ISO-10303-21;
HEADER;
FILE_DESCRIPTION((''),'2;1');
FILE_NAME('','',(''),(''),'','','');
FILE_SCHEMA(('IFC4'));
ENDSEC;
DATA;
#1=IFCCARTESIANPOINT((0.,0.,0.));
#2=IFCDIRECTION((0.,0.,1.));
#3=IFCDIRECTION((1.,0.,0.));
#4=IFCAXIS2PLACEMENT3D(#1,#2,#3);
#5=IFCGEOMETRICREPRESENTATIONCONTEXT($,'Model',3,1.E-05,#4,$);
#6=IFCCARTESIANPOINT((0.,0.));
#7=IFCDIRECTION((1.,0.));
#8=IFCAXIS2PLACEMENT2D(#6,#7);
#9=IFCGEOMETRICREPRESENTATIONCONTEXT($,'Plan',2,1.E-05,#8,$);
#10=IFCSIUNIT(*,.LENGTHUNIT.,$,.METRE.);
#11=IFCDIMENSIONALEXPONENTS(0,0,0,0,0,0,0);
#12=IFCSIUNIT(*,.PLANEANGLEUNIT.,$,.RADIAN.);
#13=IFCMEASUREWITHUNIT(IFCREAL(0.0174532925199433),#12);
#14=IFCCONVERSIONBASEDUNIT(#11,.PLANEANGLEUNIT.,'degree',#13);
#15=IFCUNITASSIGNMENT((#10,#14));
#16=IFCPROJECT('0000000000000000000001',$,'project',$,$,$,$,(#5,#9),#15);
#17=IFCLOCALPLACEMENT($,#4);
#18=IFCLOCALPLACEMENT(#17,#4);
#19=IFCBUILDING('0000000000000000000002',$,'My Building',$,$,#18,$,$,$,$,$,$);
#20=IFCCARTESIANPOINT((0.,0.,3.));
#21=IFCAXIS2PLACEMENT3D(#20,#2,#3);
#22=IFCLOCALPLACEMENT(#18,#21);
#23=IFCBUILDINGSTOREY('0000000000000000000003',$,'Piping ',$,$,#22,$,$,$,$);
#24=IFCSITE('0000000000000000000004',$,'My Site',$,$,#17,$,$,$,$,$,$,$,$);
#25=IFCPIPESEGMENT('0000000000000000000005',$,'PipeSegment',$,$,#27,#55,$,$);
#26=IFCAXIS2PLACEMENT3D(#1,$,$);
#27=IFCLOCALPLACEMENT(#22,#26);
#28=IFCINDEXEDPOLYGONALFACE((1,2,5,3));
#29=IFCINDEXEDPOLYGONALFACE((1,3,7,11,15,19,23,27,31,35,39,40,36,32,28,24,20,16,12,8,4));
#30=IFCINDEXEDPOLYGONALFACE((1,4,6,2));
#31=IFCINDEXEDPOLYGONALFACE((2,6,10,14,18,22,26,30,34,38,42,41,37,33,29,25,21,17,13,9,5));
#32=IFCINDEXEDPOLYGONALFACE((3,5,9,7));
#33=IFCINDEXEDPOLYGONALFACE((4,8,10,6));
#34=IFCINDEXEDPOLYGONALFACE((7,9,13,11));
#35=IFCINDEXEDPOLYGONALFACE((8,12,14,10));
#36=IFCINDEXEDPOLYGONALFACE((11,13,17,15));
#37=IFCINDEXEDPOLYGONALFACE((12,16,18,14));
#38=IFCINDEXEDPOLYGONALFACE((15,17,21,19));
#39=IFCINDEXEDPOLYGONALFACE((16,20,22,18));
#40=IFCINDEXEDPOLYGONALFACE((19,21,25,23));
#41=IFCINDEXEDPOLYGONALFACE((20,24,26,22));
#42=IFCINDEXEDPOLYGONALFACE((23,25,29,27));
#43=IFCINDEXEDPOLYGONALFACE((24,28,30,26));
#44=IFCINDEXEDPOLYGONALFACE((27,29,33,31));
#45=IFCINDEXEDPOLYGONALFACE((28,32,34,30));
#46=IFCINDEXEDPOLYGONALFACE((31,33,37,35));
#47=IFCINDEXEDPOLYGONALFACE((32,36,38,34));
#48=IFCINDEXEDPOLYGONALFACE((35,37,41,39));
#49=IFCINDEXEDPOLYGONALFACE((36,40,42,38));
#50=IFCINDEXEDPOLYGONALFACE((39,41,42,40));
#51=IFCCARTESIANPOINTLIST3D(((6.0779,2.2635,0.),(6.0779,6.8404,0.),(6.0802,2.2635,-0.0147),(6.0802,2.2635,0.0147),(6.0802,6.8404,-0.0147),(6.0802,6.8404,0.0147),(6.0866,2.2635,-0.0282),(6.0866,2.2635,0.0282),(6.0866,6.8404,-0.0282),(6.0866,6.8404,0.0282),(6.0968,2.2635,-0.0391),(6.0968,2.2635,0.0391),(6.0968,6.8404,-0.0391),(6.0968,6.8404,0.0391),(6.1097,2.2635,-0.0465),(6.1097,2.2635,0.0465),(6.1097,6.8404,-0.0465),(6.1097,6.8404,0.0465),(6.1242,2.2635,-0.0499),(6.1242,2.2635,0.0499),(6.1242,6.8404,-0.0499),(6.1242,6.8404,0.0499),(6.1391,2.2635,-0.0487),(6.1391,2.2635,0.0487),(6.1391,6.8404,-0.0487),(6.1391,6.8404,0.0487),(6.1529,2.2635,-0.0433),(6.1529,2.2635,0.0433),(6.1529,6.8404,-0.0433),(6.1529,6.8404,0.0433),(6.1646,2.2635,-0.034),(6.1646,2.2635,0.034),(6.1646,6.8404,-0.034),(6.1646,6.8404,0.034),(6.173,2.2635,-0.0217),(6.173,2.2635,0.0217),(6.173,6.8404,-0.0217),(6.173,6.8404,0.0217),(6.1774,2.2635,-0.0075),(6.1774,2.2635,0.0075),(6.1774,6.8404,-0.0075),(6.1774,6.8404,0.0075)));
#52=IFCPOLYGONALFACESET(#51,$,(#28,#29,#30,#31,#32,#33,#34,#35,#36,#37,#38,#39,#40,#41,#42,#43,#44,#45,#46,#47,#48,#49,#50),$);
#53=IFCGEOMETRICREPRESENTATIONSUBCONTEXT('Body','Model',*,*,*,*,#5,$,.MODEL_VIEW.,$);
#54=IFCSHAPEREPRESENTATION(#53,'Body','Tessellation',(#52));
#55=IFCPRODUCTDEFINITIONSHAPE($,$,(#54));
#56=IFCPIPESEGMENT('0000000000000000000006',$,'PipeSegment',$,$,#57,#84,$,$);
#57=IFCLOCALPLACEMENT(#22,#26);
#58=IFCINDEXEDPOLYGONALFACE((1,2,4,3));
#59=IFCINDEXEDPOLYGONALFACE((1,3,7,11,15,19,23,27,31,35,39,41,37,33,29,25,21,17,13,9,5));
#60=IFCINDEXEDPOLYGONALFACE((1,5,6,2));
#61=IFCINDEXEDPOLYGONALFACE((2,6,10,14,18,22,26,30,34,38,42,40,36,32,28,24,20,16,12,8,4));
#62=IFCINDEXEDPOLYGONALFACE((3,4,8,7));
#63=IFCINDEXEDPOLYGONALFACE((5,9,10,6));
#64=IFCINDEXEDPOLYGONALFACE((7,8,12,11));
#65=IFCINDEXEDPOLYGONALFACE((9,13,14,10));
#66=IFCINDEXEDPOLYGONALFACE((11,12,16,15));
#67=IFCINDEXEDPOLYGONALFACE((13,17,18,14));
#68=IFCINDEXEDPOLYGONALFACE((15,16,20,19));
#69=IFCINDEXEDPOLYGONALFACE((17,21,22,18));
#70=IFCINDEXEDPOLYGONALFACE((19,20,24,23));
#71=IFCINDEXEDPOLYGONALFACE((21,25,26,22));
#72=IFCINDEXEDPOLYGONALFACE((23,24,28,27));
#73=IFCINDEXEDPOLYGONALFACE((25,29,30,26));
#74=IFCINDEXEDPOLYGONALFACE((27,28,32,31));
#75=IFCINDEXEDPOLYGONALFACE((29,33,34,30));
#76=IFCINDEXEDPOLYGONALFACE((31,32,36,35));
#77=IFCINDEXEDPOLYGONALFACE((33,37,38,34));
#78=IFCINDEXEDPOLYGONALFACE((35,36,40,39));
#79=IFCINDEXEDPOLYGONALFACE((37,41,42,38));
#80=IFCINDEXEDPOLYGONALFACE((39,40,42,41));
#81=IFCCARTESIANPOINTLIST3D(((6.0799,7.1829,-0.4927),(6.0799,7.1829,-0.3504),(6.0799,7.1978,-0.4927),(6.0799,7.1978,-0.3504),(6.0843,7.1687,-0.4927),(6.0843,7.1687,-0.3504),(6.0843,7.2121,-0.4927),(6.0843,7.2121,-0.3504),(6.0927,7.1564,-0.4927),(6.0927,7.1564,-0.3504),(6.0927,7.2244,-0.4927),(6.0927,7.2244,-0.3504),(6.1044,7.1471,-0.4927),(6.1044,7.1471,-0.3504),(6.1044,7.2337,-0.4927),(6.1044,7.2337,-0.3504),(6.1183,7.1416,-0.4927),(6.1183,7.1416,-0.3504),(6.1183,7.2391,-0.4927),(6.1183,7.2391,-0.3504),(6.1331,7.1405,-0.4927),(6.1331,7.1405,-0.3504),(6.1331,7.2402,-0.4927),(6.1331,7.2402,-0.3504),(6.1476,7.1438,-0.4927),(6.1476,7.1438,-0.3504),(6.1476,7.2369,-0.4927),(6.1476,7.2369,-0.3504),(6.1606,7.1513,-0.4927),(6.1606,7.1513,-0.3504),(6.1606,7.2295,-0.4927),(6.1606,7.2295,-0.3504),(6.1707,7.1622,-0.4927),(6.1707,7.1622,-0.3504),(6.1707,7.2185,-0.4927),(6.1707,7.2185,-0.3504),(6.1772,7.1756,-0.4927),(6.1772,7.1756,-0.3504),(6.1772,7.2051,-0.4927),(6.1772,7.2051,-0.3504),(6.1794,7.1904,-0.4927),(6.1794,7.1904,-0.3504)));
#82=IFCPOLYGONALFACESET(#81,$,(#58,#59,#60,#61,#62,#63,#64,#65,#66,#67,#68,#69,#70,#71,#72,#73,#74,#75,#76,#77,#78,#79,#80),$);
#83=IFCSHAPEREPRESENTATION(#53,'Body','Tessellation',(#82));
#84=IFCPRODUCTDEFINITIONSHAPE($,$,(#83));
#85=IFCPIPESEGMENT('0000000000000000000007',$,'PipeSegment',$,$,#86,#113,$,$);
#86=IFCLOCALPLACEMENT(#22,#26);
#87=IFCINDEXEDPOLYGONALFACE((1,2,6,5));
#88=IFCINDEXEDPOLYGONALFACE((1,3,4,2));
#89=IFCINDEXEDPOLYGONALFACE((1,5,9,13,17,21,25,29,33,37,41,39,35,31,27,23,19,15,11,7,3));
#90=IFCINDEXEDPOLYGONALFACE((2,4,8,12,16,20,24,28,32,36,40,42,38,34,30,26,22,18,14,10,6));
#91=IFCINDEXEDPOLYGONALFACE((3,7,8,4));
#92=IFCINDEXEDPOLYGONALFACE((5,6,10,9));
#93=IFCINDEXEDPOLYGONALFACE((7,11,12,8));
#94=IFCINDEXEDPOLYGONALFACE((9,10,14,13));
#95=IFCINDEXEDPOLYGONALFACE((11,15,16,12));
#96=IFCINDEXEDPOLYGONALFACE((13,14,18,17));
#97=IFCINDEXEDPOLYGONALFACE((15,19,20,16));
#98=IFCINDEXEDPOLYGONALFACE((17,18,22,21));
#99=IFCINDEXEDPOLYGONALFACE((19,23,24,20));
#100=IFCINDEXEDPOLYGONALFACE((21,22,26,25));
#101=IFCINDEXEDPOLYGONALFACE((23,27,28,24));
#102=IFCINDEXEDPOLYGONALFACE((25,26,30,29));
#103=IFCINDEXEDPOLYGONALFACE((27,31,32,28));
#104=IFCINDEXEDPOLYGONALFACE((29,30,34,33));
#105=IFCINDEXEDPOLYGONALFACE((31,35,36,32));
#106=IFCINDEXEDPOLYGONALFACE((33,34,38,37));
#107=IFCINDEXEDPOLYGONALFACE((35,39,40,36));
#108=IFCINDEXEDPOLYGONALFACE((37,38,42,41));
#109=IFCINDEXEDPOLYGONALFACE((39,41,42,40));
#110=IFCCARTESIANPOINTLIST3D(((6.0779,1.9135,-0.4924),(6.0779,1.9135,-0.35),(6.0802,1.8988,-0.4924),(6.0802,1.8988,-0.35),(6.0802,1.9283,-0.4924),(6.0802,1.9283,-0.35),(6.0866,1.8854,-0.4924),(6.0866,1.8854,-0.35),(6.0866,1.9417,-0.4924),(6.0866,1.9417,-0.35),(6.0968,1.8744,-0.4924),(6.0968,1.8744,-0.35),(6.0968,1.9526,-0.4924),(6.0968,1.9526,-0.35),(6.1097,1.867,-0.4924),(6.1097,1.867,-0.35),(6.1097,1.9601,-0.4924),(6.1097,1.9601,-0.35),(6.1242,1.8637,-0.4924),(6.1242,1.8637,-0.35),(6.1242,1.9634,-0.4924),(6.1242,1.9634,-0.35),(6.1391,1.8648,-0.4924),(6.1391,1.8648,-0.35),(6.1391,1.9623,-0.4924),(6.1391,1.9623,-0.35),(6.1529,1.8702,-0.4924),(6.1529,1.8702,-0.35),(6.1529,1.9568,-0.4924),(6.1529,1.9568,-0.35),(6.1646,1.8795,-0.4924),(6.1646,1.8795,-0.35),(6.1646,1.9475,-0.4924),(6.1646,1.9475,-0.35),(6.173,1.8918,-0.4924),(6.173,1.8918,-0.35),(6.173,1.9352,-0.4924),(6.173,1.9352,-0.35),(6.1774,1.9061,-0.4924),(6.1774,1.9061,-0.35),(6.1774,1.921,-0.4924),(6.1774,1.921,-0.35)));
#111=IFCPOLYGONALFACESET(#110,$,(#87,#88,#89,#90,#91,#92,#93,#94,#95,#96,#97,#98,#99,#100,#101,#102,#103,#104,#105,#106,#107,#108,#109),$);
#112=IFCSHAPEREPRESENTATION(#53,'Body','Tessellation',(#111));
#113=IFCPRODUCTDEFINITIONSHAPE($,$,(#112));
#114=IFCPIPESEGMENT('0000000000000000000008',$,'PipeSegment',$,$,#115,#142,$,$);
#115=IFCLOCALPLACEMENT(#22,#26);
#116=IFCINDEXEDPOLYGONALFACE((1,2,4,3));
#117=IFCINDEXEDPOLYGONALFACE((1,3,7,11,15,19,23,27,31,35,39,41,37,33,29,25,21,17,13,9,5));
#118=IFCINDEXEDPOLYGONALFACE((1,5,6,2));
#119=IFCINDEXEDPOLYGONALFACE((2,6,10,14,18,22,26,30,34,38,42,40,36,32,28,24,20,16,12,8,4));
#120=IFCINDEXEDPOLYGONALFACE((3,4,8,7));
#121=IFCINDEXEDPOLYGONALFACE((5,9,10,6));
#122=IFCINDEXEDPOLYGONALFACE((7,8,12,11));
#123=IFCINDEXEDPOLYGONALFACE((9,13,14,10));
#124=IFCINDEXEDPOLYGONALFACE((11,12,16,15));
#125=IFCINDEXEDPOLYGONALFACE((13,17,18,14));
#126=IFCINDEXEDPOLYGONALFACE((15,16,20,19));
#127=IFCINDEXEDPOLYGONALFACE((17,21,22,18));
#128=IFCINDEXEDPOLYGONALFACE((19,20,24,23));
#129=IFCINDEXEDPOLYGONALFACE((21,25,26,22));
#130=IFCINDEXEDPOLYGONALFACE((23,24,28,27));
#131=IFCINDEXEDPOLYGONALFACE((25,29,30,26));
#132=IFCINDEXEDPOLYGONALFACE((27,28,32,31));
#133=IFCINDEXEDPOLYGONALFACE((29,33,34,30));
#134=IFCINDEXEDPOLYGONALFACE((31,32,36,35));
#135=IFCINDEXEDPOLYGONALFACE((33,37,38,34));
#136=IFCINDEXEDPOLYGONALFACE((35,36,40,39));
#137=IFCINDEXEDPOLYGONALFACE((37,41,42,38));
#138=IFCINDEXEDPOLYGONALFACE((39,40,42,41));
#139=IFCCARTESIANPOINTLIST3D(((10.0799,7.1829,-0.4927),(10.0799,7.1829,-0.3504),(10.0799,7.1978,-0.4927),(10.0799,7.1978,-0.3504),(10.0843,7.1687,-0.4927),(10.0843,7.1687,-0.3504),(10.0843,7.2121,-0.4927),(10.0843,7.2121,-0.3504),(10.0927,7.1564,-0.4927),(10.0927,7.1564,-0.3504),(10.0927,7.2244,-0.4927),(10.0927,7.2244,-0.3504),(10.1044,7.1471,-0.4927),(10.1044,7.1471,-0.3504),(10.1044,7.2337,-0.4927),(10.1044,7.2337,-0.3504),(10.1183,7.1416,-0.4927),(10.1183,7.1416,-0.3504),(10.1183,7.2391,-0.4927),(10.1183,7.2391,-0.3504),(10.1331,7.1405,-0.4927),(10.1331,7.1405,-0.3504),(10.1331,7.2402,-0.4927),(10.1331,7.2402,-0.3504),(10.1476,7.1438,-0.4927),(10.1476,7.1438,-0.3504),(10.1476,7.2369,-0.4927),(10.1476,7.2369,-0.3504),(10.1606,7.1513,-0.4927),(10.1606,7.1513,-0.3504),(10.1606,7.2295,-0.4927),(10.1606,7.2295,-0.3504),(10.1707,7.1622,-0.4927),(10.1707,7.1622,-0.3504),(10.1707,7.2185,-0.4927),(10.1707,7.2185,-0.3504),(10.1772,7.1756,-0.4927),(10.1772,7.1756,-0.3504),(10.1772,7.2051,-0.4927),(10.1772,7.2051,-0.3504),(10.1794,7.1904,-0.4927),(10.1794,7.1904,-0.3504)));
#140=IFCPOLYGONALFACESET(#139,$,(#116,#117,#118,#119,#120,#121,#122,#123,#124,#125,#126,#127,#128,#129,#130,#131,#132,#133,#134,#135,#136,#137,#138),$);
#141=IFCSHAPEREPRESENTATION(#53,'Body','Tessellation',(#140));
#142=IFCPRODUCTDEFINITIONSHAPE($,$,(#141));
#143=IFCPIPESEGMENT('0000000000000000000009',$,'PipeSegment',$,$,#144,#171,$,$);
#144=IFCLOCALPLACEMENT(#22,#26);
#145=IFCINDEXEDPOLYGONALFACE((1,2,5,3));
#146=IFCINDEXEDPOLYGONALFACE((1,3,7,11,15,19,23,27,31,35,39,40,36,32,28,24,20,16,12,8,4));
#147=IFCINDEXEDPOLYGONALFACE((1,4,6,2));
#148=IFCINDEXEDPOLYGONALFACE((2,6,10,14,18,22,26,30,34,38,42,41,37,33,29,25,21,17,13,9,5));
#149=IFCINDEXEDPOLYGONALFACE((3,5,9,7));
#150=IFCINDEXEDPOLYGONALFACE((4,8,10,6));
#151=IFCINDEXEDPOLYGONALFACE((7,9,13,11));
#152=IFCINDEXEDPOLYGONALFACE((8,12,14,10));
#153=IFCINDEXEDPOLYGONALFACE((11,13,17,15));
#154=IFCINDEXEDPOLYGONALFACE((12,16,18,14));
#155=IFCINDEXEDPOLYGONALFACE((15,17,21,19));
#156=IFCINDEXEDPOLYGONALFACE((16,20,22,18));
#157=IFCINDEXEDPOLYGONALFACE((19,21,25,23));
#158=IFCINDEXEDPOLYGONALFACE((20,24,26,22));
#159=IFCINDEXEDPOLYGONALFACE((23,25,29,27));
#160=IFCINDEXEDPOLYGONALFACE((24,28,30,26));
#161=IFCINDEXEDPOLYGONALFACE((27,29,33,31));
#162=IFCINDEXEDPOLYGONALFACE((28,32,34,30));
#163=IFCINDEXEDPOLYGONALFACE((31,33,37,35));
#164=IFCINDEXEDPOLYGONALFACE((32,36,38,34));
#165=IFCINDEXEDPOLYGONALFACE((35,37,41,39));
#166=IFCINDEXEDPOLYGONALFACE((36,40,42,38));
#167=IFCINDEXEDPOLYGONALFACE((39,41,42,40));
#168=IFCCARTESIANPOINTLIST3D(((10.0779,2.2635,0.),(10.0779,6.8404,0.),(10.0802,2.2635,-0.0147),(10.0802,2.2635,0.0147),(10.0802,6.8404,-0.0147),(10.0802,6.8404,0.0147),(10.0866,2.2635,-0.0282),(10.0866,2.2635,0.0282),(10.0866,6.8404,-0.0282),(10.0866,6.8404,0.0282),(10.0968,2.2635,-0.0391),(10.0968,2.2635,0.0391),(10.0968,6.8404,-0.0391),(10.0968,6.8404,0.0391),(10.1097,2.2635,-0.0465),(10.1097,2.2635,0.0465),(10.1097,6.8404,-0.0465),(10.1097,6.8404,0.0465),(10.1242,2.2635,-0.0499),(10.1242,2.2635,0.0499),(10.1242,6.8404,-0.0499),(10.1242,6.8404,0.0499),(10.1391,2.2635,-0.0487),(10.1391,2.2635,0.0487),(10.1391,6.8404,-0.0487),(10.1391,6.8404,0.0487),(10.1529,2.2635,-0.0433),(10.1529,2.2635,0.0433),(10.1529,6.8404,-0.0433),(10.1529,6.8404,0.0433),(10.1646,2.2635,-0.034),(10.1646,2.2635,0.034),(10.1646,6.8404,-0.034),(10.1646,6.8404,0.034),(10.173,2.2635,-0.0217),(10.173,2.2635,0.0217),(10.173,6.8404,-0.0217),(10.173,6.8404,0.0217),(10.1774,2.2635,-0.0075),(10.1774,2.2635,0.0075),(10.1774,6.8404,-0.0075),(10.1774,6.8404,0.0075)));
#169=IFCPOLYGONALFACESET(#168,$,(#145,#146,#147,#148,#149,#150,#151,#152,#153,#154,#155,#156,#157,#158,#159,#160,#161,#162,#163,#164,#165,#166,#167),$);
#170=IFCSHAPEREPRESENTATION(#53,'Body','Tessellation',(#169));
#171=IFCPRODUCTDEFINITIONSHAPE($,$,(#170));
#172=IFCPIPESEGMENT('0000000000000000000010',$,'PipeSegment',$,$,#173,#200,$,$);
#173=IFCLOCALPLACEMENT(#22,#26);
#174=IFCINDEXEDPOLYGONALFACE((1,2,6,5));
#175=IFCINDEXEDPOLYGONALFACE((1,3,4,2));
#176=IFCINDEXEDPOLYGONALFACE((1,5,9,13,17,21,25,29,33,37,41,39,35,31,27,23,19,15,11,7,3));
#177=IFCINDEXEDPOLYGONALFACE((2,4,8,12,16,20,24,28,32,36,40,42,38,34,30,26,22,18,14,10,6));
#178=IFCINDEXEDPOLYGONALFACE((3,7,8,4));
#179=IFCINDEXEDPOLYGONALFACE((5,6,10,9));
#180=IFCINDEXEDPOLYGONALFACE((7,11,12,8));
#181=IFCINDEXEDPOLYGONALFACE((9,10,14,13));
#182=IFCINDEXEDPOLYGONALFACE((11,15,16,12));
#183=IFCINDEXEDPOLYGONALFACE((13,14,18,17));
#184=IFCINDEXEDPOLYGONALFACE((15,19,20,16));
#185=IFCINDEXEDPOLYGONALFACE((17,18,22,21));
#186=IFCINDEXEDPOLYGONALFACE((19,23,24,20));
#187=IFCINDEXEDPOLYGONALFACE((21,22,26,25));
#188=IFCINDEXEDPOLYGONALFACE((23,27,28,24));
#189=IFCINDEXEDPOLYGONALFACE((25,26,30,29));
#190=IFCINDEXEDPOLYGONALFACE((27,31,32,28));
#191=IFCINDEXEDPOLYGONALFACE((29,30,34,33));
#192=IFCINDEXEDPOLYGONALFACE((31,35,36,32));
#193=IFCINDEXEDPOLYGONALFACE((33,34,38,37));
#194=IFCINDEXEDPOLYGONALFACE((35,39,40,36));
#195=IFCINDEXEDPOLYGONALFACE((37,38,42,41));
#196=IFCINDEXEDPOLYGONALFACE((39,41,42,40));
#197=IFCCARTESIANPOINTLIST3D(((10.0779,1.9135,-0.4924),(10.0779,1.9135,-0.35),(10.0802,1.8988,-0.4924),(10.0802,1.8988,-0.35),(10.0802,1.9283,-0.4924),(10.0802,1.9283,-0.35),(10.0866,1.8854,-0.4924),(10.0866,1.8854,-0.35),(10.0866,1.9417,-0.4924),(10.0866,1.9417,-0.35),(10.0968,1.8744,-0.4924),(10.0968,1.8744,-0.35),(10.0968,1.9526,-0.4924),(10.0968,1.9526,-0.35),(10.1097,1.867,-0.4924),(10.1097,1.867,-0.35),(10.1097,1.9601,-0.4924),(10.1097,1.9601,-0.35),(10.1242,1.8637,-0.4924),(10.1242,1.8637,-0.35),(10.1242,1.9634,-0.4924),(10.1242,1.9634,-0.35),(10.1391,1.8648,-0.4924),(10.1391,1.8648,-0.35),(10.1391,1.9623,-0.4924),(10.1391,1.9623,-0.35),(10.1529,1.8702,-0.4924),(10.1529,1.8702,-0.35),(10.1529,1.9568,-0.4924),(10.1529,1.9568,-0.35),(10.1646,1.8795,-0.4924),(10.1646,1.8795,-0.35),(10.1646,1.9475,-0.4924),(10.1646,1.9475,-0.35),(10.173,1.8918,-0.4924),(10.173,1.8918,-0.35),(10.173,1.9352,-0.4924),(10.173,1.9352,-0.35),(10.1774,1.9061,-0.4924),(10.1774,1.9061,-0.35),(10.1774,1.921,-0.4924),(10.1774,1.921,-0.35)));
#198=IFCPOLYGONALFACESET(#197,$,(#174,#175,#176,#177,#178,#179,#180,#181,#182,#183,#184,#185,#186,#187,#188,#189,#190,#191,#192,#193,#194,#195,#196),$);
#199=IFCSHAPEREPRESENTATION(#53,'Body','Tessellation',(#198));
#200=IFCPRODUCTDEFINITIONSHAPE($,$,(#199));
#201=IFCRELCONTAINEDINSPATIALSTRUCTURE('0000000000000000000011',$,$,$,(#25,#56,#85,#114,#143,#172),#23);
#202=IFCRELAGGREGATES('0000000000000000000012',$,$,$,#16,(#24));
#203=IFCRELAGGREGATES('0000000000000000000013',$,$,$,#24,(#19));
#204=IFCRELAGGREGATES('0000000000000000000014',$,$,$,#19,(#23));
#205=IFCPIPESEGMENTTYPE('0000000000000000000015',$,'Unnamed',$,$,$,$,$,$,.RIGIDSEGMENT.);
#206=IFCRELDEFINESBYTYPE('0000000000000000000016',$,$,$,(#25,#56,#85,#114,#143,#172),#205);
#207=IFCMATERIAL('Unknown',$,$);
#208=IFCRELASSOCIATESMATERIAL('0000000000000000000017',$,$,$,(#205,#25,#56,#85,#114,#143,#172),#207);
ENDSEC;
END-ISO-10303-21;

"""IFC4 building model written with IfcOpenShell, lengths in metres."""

from ifc_helpers import new_model, entity, si_unit, converted_unit, frame, origin_with_axes, origin_2d_with_axis, place, context, subcontext, project, spatial, circle, extrude, material, material_profile, profile_set, profile_usage, type_object, element, save


model = new_model("IFC4")

# Units and contexts
model_context = context("Model", 3, precision=1e-05, world=origin_with_axes())
plan_context = context("Plan", 2, precision=1e-05, world=origin_2d_with_axis())
body_context = subcontext(model_context, "Body", "Model", "MODEL_VIEW")
ifc_project = project(units=[si_unit("LENGTHUNIT", "METRE"), converted_unit("PLANEANGLEUNIT", "degree", entity("IfcReal", 0.0174532925199433), si_unit("PLANEANGLEUNIT", "RADIAN"), dimensions=[0, 0, 0, 0, 0, 0, 0])], contexts=[model_context, plan_context])

# Site, building, storey
site_placement = place(None, origin_with_axes())
site = spatial("IfcSite", under=ifc_project, at=site_placement, Name="My Site")
building_placement = place(site_placement, origin_with_axes())
building = spatial("IfcBuilding", under=site, at=building_placement, Name="My Building")
storey_placement = place(building_placement, frame((0.0, 0.0, 3.0), z_axis=(0.0, 0.0, 1.0), x_axis=(1.0, 0.0, 0.0)))
storey = spatial("IfcBuildingStorey", under=building, at=storey_placement, Name="Piping ")

# Pipe segments
ifc_material = material(Name="Unknown")
ifc_material_profile = material_profile(ifc_material, circle(Radius=0.05))
ifc_profile_set = profile_set([ifc_material_profile])
pipe_segment_type = type_object("IfcPipeSegmentType", Name="Unnamed", PredefinedType="RIGIDSEGMENT", material=ifc_profile_set)
ifc_profile_usage_1 = profile_usage(ifc_profile_set, cardinal=5)
pipe_segment_1_placement = place(storey_placement, frame((6.1279, 2.2635, 0.0), z_axis=(0.0, 1.0, 0.0), x_axis=(-1.0, 0.0, 0.0)))
element("IfcPipeSegment", 1, at=pipe_segment_1_placement, inside=storey, type_object=pipe_segment_type, material=ifc_profile_usage_1, Name="PipeSegment", context=body_context, shape_type="SweptSolid", body=[
    extrude(circle(Radius=0.05), origin_with_axes(), (0.0, 0.0, 1.0), 4.5768),
])
ifc_profile_usage_2 = profile_usage(ifc_profile_set, cardinal=5)
pipe_segment_2_placement = place(storey_placement, frame((6.1294, 7.1904, -0.3504), z_axis=(0.0, 0.0, -1.0), x_axis=(1.0, 0.0, 0.0)))
element("IfcPipeSegment", 2, at=pipe_segment_2_placement, inside=storey, type_object=pipe_segment_type, material=ifc_profile_usage_2, Name="PipeSegment", context=body_context, shape_type="SweptSolid", body=[
    extrude(circle(Radius=0.05), origin_with_axes(), (0.0, 0.0, 1.0), 0.1424),
])
ifc_profile_usage_3 = profile_usage(ifc_profile_set, cardinal=5)
pipe_segment_3_placement = place(storey_placement, frame((6.1279, 1.9135, -0.35), z_axis=(0.0, 0.0, -1.0), x_axis=(-1.0, 0.0, 0.0)))
element("IfcPipeSegment", 3, at=pipe_segment_3_placement, inside=storey, type_object=pipe_segment_type, material=ifc_profile_usage_3, Name="PipeSegment", context=body_context, shape_type="SweptSolid", body=[
    extrude(circle(Radius=0.05), origin_with_axes(), (0.0, 0.0, 1.0), 0.1424),
])
ifc_profile_usage_4 = profile_usage(ifc_profile_set, cardinal=5)
pipe_segment_4_placement = place(storey_placement, frame((10.1294, 7.1904, -0.3504), z_axis=(0.0, 0.0, -1.0), x_axis=(1.0, 0.0, 0.0)))
element("IfcPipeSegment", 4, at=pipe_segment_4_placement, inside=storey, type_object=pipe_segment_type, material=ifc_profile_usage_4, Name="PipeSegment", context=body_context, shape_type="SweptSolid", body=[
    extrude(circle(Radius=0.05), origin_with_axes(), (0.0, 0.0, 1.0), 0.1424),
])
ifc_profile_usage_5 = profile_usage(ifc_profile_set, cardinal=5)
pipe_segment_5_placement = place(storey_placement, frame((10.1279, 2.2635, 0.0), z_axis=(0.0, 1.0, 0.0), x_axis=(-1.0, 0.0, 0.0)))
element("IfcPipeSegment", 5, at=pipe_segment_5_placement, inside=storey, type_object=pipe_segment_type, material=ifc_profile_usage_5, Name="PipeSegment", context=body_context, shape_type="SweptSolid", body=[
    extrude(circle(Radius=0.05), origin_with_axes(), (0.0, 0.0, 1.0), 4.5768),
])
ifc_profile_usage_6 = profile_usage(ifc_profile_set, cardinal=5)
pipe_segment_6_placement = place(storey_placement, frame((10.1279, 1.9135, -0.35), z_axis=(0.0, 0.0, -1.0), x_axis=(-1.0, 0.0, 0.0)))
element("IfcPipeSegment", 6, at=pipe_segment_6_placement, inside=storey, type_object=pipe_segment_type, material=ifc_profile_usage_6, Name="PipeSegment", context=body_context, shape_type="SweptSolid", body=[
    extrude(circle(Radius=0.05), origin_with_axes(), (0.0, 0.0, 1.0), 0.1424),
])

save(model, "model.ifc")
